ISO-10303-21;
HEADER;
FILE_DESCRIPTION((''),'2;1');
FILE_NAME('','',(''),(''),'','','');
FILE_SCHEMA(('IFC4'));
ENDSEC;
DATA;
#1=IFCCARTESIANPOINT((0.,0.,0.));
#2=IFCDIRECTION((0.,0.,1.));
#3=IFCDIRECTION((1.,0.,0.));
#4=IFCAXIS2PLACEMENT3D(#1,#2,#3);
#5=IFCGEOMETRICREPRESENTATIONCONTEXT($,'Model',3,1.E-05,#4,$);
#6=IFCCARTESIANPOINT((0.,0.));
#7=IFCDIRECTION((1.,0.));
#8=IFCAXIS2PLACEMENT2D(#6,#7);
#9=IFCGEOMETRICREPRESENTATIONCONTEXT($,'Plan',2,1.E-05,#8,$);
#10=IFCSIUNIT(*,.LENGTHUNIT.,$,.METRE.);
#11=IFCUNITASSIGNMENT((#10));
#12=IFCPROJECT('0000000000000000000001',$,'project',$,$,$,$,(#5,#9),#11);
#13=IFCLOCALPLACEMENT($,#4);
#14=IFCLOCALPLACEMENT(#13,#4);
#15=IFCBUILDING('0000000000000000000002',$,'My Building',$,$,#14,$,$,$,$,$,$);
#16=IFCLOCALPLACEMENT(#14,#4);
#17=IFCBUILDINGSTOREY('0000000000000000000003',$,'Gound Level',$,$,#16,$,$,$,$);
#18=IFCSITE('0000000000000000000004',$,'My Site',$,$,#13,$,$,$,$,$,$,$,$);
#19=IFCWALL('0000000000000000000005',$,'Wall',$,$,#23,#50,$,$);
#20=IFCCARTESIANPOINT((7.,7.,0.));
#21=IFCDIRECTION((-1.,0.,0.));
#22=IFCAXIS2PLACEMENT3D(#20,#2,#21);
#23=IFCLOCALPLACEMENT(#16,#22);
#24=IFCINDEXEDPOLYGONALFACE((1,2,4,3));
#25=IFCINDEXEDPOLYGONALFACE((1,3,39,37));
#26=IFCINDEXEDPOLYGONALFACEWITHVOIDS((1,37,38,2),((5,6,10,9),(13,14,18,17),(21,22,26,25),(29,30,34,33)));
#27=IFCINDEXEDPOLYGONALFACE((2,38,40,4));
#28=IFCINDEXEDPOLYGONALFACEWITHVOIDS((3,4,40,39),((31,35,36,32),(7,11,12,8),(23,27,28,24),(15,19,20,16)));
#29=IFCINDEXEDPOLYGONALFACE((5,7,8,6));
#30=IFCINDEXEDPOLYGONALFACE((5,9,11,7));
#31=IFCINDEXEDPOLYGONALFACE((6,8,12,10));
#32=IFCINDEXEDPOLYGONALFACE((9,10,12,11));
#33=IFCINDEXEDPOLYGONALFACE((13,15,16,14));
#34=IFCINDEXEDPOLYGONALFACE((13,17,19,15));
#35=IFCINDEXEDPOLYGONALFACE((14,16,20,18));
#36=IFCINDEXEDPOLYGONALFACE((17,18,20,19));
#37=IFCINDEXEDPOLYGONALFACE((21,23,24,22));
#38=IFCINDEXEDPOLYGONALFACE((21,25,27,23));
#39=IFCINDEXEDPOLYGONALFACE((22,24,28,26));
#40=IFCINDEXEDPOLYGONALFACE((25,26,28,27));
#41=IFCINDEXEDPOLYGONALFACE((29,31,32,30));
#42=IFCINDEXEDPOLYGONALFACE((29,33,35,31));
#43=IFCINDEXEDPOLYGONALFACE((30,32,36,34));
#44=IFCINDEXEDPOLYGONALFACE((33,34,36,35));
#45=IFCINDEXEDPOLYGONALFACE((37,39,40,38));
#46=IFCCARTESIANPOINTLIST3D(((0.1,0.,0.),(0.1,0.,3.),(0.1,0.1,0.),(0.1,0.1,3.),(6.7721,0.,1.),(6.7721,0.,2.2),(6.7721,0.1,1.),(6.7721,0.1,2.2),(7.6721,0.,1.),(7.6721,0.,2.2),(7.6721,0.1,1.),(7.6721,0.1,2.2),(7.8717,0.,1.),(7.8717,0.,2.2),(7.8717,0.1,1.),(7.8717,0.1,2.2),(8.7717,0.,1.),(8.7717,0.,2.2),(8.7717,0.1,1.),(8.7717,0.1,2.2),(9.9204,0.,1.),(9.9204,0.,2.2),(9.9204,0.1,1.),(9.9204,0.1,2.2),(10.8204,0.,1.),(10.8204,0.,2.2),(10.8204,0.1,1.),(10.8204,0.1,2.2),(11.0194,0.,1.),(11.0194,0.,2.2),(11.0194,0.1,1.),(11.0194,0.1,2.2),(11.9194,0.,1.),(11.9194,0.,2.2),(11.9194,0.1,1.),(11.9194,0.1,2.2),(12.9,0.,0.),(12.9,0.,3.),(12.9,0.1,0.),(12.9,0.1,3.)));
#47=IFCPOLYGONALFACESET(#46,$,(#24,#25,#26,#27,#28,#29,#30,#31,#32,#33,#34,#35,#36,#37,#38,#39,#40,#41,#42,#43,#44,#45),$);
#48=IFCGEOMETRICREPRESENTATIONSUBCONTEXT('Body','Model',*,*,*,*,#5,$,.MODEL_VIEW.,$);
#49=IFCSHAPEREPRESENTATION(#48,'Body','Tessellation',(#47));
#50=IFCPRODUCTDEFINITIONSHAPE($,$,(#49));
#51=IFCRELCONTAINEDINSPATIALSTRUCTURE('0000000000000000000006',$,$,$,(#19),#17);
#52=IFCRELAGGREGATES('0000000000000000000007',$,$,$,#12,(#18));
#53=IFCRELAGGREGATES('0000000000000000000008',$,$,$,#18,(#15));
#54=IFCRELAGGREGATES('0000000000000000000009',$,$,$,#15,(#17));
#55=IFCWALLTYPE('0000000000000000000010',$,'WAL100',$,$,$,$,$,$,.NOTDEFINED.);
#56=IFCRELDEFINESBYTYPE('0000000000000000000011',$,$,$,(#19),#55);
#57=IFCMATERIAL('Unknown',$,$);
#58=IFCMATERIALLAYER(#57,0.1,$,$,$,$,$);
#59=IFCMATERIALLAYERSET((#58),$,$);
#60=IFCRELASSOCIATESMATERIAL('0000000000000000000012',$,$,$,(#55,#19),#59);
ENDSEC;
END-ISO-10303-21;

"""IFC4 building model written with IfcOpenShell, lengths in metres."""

from ifc_helpers import new_model, si_unit, frame, origin_with_axes, origin_2d_with_axis, place, context, subcontext, project, spatial, line, indexed_curve, outline, extrude, source, transform, mapped, material, layer, layer_set, layer_usage, type_object, element, save


model = new_model("IFC4")

# Units and contexts
model_context = context("Model", 3, precision=1e-05, world=origin_with_axes())
plan_context = context("Plan", 2, precision=1e-05, world=origin_2d_with_axis())
body_context = subcontext(model_context, "Body", "Model", "MODEL_VIEW")
ifc_project = project(units=[si_unit("LENGTHUNIT", "METRE")], contexts=[model_context, plan_context])

# Site, building, storey
site_placement = place(None, origin_with_axes())
site = spatial("IfcSite", under=ifc_project, at=site_placement, Name="My Site")
building_placement = place(site_placement, origin_with_axes())
building = spatial("IfcBuilding", under=site, at=building_placement, Name="My Building")
storey_placement = place(building_placement, origin_with_axes())
storey = spatial("IfcBuildingStorey", under=building, at=storey_placement, Name="Gound Level")

# Wall, openings
ifc_material = material(Name="Unknown")
ifc_layer = layer(ifc_material, 0.1)
ifc_layer_set = layer_set([ifc_layer])
wall_type = type_object("IfcWallType", Name="WAL100", PredefinedType="NOTDEFINED", material=ifc_layer_set)
shared_shape_1 = source(origin_with_axes(), body_context, "Body", "SweptSolid", [
    extrude(outline(indexed_curve([(0.0, 0.0), (0.9, 0.0), (0.9, 1.2), (0.0, 1.2)], segments=[line(1, 2, 3, 4, 1)])), frame((0.0, -0.6, 0.0), z_axis=(0.0, -1.0, 0.0), x_axis=(1.0, 0.0, 0.0)), (0.0, 0.0, -1.0), 1.2),
])
ifc_layer_usage_1 = layer_usage(ifc_layer_set, "AXIS2", "POSITIVE", 0.0)
wall_1_placement = place(storey_placement, frame((7.0, 7.0, 0.0), z_axis=(0.0, 0.0, 1.0), x_axis=(-1.0, 0.0, 0.0)))
wall_1 = element("IfcWall", 1, at=wall_1_placement, inside=storey, type_object=wall_type, material=ifc_layer_usage_1, Name="Wall", context=body_context, shape_type="SweptSolid", body=[
    extrude(outline(indexed_curve([(0.1, 0.0), (0.1, 0.1), (12.9, 0.1), (12.9, 0.0)], segments=[line(1, 2, 3, 4, 1)])), origin_with_axes(), (0.0, 0.0, 1.0), 3.0),
])
opening_1_placement = place(wall_1_placement, frame((7.6721, 0.1, 1.0), z_axis=(0.0, 0.0, 1.0), x_axis=(-1.0, 0.0, 0.0)))
element("IfcOpeningElement", 2, at=opening_1_placement, cuts=wall_1, PredefinedType="OPENING", context=body_context, shape_type="MappedRepresentation", body=[
    mapped(shared_shape_1, transform((0.0, 0.0, 0.0), x_axis=(1.0, 0.0, 0.0), y_axis=(0.0, 1.0, 0.0), z_axis=(0.0, 0.0, 1.0), scale=1.0)),
])
opening_2_placement = place(wall_1_placement, frame((8.7717, 0.1, 1.0), z_axis=(0.0, 0.0, 1.0), x_axis=(-1.0, 0.0, 0.0)))
element("IfcOpeningElement", 3, at=opening_2_placement, cuts=wall_1, PredefinedType="OPENING", context=body_context, shape_type="MappedRepresentation", body=[
    mapped(shared_shape_1, transform((0.0, 0.0, 0.0), x_axis=(1.0, 0.0, 0.0), y_axis=(0.0, 1.0, 0.0), z_axis=(0.0, 0.0, 1.0), scale=1.0)),
])
opening_3_placement = place(wall_1_placement, frame((10.8204, 0.1, 1.0), z_axis=(0.0, 0.0, 1.0), x_axis=(-1.0, 0.0, 0.0)))
element("IfcOpeningElement", 4, at=opening_3_placement, cuts=wall_1, PredefinedType="OPENING", context=body_context, shape_type="MappedRepresentation", body=[
    mapped(shared_shape_1, transform((0.0, 0.0, 0.0), x_axis=(1.0, 0.0, 0.0), y_axis=(0.0, 1.0, 0.0), z_axis=(0.0, 0.0, 1.0), scale=1.0)),
])
opening_4_placement = place(wall_1_placement, frame((11.9194, 0.1, 1.0), z_axis=(0.0, 0.0, 1.0), x_axis=(-1.0, 0.0, 0.0)))
element("IfcOpeningElement", 5, at=opening_4_placement, cuts=wall_1, PredefinedType="OPENING", context=body_context, shape_type="MappedRepresentation", body=[
    mapped(shared_shape_1, transform((0.0, 0.0, 0.0), x_axis=(1.0, 0.0, 0.0), y_axis=(0.0, 1.0, 0.0), z_axis=(0.0, 0.0, 1.0), scale=1.0)),
])

save(model, "model.ifc")
